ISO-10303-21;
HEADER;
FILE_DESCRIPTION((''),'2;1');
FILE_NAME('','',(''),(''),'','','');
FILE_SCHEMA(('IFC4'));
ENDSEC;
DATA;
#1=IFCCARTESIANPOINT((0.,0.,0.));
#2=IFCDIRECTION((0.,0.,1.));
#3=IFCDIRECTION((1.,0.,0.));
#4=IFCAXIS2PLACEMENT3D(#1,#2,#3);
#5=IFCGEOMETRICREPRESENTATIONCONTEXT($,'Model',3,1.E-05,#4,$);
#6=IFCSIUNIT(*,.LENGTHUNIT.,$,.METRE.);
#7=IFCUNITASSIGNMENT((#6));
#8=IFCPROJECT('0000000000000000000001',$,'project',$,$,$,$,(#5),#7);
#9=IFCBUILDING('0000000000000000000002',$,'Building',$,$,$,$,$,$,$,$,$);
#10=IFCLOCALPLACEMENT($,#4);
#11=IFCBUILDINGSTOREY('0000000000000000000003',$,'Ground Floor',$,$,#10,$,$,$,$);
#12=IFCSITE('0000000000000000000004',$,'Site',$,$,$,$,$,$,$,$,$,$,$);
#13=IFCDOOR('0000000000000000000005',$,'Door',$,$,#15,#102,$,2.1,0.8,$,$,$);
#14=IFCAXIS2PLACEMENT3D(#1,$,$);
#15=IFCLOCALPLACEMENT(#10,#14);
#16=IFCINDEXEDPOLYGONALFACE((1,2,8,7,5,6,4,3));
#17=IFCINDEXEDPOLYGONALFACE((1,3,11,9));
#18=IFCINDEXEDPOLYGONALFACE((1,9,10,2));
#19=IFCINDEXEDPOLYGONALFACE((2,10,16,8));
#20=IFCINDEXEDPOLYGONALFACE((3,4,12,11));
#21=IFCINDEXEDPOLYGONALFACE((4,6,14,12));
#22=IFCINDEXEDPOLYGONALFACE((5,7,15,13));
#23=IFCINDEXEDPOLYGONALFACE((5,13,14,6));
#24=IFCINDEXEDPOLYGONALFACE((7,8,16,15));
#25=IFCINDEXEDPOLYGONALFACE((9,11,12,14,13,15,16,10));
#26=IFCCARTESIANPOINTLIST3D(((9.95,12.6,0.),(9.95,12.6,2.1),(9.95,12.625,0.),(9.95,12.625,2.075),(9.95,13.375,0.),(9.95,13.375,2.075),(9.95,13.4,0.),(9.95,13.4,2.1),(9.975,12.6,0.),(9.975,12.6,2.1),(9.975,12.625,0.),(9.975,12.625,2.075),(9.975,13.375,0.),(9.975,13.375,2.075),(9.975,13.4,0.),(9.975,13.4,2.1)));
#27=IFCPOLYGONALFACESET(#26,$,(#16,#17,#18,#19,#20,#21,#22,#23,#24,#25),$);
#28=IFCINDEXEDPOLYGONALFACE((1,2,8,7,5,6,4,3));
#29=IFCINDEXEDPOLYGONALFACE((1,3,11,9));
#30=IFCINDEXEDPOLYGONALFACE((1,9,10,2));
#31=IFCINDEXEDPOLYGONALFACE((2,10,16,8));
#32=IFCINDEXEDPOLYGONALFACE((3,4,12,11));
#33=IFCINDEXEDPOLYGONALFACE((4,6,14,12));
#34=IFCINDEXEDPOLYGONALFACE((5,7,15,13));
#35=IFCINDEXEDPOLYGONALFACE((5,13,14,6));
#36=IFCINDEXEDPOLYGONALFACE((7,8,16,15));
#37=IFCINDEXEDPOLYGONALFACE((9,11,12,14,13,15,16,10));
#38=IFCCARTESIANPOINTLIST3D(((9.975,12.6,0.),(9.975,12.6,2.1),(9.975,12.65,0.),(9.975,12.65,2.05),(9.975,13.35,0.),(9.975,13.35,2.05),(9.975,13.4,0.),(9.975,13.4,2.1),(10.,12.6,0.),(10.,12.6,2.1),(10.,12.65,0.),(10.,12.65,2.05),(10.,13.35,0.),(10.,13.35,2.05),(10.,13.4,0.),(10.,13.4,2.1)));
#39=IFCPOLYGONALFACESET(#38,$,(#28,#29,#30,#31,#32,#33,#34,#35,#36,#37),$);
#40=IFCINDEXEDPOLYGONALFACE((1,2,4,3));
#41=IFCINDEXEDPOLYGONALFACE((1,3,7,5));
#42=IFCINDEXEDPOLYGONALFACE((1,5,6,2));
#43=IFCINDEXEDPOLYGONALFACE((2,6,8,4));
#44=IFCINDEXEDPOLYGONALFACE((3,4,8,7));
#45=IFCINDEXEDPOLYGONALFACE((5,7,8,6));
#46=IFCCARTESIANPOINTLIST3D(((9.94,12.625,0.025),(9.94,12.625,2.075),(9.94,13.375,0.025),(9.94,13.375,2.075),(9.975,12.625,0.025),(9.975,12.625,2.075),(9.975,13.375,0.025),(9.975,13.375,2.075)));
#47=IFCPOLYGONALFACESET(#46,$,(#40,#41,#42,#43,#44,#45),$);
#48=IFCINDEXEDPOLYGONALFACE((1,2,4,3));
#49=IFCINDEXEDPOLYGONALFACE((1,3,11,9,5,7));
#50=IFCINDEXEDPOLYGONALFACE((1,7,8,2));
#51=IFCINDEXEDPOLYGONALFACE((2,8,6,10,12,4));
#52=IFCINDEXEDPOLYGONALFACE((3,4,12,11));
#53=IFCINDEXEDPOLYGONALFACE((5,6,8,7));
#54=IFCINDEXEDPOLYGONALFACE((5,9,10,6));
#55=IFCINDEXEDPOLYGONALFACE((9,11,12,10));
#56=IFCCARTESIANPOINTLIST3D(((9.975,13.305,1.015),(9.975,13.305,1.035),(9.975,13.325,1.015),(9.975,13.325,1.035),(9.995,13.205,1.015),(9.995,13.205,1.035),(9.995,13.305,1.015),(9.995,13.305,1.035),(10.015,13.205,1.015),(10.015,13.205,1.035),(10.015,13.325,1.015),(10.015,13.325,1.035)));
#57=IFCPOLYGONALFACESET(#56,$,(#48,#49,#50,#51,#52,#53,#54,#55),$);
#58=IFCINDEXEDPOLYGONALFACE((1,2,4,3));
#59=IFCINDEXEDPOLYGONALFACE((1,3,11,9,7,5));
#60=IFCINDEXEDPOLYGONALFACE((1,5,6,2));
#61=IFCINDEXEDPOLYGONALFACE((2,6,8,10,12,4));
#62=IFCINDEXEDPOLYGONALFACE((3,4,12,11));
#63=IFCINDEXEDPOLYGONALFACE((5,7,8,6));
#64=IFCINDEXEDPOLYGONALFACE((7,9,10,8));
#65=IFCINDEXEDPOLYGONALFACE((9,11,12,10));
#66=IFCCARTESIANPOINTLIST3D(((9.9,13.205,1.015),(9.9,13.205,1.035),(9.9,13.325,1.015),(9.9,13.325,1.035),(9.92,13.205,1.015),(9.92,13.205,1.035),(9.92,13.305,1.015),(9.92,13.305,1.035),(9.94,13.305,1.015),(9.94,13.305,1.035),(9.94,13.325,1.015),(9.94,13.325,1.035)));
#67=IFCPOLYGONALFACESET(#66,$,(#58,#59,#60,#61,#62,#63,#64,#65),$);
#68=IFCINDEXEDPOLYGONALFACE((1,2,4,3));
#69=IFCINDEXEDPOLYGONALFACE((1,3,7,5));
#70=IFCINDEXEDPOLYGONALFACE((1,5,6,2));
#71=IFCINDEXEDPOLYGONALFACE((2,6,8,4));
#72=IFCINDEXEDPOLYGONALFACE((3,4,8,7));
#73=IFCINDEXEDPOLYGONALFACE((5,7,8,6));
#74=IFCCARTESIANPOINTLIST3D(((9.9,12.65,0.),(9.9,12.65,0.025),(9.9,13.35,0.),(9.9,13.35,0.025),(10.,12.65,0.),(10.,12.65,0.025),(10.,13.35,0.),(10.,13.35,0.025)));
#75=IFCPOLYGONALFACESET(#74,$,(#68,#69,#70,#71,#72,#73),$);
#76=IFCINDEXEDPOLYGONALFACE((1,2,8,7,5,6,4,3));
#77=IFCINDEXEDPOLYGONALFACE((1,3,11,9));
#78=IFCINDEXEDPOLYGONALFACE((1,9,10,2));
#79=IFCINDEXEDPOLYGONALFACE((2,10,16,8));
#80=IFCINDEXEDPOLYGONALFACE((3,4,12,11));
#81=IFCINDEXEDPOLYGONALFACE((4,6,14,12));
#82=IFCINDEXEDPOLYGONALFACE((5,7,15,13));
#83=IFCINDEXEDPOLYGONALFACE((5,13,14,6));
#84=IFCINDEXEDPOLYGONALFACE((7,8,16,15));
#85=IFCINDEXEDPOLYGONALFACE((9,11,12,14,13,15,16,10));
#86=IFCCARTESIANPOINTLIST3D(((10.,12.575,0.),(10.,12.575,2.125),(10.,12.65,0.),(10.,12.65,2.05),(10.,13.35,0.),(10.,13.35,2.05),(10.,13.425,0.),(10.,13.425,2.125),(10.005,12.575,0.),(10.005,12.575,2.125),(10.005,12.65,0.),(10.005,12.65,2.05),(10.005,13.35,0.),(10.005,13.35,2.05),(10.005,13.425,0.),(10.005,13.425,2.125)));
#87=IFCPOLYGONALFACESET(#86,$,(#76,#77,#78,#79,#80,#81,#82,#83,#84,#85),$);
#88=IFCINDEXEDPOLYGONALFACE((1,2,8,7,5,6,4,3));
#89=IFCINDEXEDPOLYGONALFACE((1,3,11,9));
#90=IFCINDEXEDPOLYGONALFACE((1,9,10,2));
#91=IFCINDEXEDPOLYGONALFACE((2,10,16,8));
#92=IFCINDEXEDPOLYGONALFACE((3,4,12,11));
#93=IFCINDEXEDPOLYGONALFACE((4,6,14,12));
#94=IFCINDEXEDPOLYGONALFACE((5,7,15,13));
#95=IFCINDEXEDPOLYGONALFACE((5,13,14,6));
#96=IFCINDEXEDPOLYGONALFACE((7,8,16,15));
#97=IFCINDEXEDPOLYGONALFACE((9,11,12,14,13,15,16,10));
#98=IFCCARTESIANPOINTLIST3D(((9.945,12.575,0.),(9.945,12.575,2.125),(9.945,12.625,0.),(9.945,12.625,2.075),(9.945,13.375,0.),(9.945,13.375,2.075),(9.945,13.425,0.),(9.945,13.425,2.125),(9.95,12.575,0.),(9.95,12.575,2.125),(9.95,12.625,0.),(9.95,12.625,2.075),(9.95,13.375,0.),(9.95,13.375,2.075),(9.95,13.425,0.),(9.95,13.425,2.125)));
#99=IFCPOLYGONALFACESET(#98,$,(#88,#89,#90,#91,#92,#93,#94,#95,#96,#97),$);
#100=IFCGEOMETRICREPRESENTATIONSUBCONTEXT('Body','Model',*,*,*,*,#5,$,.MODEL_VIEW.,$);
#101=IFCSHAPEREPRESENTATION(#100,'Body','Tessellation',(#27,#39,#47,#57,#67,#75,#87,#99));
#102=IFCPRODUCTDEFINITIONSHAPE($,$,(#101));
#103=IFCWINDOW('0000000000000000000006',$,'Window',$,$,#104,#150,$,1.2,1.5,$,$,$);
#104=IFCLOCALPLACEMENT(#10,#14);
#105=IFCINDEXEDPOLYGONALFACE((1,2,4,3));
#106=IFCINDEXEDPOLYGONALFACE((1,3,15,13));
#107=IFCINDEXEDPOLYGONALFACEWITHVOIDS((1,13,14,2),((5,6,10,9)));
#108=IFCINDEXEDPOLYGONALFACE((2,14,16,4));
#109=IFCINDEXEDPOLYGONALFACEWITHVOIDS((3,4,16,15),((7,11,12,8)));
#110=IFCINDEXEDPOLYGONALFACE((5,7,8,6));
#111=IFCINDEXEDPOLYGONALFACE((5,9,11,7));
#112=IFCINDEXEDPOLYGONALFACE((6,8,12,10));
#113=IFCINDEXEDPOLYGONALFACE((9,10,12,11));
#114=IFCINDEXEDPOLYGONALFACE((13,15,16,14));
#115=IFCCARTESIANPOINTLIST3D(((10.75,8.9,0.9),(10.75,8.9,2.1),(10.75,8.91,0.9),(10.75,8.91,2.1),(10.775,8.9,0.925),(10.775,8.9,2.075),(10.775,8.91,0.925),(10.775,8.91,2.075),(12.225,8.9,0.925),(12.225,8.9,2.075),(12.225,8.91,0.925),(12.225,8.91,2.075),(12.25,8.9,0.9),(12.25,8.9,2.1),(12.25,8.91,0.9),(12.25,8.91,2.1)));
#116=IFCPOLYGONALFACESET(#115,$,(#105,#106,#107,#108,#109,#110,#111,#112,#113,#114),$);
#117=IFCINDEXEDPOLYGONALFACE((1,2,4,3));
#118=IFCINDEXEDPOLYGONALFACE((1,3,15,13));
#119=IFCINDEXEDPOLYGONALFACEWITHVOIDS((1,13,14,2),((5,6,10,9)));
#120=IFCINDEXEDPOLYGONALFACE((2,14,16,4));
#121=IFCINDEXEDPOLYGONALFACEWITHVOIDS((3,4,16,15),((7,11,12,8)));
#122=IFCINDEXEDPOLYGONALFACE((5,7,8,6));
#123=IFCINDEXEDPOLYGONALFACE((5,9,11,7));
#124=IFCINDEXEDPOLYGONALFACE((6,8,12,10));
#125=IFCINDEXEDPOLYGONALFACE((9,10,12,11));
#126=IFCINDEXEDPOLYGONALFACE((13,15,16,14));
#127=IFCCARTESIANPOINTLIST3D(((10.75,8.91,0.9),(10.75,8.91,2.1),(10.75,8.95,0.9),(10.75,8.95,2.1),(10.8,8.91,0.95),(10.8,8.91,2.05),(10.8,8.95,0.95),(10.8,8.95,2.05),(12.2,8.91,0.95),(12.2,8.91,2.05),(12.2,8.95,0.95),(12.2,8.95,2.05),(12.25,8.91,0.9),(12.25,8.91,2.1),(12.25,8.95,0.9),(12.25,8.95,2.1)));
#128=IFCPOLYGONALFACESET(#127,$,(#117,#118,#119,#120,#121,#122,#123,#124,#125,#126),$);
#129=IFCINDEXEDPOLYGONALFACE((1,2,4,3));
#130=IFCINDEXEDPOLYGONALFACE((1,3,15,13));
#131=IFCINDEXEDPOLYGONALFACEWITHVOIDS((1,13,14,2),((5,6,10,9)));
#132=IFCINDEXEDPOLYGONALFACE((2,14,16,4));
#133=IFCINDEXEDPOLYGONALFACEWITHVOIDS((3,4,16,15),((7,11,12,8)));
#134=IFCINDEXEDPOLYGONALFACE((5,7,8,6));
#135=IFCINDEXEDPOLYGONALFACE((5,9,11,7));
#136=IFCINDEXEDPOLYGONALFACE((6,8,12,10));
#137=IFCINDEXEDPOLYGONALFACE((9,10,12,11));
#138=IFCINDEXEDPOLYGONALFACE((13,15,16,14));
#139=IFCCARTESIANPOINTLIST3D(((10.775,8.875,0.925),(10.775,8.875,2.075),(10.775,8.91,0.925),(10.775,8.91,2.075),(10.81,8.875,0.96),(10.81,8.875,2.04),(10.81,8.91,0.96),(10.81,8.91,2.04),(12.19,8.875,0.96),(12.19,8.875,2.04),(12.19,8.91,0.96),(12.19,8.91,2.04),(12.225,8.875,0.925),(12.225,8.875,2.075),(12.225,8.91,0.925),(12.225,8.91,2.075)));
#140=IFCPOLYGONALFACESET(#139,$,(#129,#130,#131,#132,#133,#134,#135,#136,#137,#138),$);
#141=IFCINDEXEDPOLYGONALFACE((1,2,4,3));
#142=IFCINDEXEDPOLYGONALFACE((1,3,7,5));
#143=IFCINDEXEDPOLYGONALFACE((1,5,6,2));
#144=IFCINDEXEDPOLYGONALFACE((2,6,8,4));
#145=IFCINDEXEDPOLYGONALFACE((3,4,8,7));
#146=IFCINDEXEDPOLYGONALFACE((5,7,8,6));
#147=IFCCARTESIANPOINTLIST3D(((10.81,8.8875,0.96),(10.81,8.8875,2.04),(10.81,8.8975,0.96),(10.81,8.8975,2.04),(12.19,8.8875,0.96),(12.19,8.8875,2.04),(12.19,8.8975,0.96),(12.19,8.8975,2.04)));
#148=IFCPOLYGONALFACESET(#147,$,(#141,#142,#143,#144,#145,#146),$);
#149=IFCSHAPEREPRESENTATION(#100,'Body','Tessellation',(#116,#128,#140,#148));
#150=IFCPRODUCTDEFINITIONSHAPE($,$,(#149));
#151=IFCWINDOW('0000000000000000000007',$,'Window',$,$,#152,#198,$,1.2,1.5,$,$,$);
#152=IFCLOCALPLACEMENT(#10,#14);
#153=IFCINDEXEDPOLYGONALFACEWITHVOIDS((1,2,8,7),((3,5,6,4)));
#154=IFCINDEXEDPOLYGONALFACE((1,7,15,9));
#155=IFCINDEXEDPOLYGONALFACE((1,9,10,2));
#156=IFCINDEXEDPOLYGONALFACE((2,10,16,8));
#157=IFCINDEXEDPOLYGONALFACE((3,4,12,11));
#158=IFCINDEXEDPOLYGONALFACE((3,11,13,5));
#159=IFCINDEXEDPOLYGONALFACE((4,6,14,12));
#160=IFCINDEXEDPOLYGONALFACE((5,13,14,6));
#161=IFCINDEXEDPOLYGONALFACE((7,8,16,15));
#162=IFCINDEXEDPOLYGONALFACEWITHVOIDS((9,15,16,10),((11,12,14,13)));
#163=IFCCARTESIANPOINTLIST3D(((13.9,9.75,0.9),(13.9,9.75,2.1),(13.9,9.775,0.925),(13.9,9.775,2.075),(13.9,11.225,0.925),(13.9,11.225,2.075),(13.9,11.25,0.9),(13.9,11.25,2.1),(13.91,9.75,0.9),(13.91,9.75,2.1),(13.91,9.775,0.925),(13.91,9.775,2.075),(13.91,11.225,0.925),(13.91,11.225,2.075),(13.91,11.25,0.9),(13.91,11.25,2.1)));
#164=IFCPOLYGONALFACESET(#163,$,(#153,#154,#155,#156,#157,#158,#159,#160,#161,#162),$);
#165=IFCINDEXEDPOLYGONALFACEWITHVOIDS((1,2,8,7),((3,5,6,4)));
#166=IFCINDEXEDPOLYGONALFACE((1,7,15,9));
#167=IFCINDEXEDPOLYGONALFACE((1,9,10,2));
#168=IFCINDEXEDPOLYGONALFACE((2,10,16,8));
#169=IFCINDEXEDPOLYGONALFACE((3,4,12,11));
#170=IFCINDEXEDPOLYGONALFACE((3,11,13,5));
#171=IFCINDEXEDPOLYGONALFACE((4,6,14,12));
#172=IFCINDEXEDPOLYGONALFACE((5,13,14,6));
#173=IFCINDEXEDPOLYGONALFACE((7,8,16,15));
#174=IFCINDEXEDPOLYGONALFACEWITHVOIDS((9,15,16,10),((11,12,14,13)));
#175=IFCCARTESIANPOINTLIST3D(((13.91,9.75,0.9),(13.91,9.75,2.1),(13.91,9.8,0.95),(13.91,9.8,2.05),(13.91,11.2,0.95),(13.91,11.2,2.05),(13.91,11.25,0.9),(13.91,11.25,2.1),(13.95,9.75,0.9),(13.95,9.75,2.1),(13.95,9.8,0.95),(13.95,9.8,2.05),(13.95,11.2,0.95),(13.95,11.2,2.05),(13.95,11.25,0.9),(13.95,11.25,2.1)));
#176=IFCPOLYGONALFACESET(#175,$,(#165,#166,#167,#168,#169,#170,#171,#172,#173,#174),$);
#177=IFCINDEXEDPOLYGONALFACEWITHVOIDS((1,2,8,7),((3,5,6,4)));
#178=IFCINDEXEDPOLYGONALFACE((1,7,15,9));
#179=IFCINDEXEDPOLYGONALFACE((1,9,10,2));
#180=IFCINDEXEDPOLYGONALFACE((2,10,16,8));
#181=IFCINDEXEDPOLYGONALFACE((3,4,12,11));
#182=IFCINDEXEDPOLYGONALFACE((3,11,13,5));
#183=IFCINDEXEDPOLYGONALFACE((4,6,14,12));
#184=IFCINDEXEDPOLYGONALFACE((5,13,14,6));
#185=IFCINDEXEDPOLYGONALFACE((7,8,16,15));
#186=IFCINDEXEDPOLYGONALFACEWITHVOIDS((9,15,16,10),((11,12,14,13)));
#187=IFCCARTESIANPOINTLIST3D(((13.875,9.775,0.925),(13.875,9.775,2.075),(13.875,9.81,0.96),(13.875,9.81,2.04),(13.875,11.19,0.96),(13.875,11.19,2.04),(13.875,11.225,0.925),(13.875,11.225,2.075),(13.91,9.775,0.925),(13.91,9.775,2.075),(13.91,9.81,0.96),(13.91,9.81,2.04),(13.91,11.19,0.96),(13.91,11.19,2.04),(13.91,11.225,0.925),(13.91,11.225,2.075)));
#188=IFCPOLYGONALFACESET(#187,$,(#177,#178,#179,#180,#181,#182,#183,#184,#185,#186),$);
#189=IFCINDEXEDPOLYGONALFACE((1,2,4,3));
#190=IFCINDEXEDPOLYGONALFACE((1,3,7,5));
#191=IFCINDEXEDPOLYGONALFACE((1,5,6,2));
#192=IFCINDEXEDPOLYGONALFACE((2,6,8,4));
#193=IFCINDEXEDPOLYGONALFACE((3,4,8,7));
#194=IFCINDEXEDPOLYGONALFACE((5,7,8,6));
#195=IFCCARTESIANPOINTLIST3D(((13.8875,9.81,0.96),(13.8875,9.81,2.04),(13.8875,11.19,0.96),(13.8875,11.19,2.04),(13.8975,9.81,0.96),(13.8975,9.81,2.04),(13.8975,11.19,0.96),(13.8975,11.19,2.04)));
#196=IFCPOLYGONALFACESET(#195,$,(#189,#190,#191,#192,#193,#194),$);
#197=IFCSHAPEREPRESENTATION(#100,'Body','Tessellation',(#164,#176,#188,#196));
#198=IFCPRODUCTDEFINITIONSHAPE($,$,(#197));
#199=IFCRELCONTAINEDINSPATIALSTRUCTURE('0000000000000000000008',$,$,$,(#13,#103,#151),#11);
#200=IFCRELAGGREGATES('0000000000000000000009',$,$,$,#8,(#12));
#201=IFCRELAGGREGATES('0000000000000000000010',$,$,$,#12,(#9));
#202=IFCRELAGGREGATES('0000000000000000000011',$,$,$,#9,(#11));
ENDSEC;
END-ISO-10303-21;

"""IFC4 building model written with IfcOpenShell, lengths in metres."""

from ifc_helpers import new_model, si_unit, frame, origin_with_axes, place, context, subcontext, project, spatial, line, indexed_curve, outline, extrude, element, save


model = new_model("IFC4")

# Units and contexts
model_context = context("Model", 3, precision=1e-05, world=origin_with_axes())
body_context = subcontext(model_context, "Body", "Model", "MODEL_VIEW")
ifc_project = project(units=[si_unit("LENGTHUNIT", "METRE")], contexts=[model_context])

# Site, building, storey
site = spatial("IfcSite", under=ifc_project, Name="Site")
building = spatial("IfcBuilding", under=site, Name="Building")
storey_placement = place(None, origin_with_axes())
storey = spatial("IfcBuildingStorey", under=building, at=storey_placement, Name="Ground Floor")

# Door
door_1_placement = place(storey_placement, frame((10.0, 12.6, 0.0), z_axis=(0.0, 0.0, 1.0), x_axis=(0.0, 1.0, 0.0)))
element("IfcDoor", 1, at=door_1_placement, inside=storey, Name="Door", OverallHeight=2.1, OverallWidth=0.8, context=body_context, shape_type="SweptSolid", body=[
    extrude(outline(indexed_curve([(0.0, 0.0), (0.0, 2.1), (0.8, 2.1), (0.8, 0.0), (0.775, 0.0), (0.775, 2.075), (0.025, 2.075), (0.025, 0.0)], segments=[line(1, 2, 3, 4, 5, 6, 7, 8, 1)])), frame((0.0, 0.025, 0.0), z_axis=(0.0, -1.0, 0.0), x_axis=(1.0, 0.0, 0.0)), (0.0, 0.0, -1.0), 0.025),
    extrude(outline(indexed_curve([(0.0, 0.0), (0.0, 2.1), (0.8, 2.1), (0.8, 0.0), (0.75, 0.0), (0.75, 2.05), (0.05, 2.05), (0.05, 0.0)], segments=[line(1, 2, 3, 4, 5, 6, 7, 8, 1)])), frame((0.0, 0.0, 0.0), z_axis=(0.0, -1.0, 0.0), x_axis=(1.0, 0.0, 0.0)), (0.0, 0.0, -1.0), 0.025),
    extrude(outline(indexed_curve([(0.0, 0.0), (0.75, 0.0), (0.75, 0.035), (0.0, 0.035)], segments=[line(1, 2, 3, 4, 1)])), frame((0.025, 0.025, 0.025), z_axis=(0.0, 0.0, 1.0), x_axis=(1.0, 0.0, 0.0)), (0.0, 0.0, 1.0), 2.05),
    extrude(outline(indexed_curve([(0.0, 0.0), (0.0, -0.04), (-0.12, -0.04), (-0.12, -0.02), (-0.02, -0.02), (-0.02, 0.0)], segments=[line(1, 2, 3, 4, 5, 6, 1)])), frame((0.725, 0.025, 1.015), z_axis=(0.0, 0.0, 1.0), x_axis=(1.0, 0.0, 0.0)), (0.0, 0.0, 1.0), 0.02),
    extrude(outline(indexed_curve([(0.0, 0.0), (0.0, 0.04), (-0.12, 0.04), (-0.12, 0.02), (-0.02, 0.02), (-0.02, 0.0)], segments=[line(1, 2, 3, 4, 5, 6, 1)])), frame((0.725, 0.06, 1.015), z_axis=(0.0, 0.0, 1.0), x_axis=(1.0, 0.0, 0.0)), (0.0, 0.0, 1.0), 0.02),
    extrude(outline(indexed_curve([(0.0, 0.0), (0.7, 0.0), (0.7, 0.1), (0.0, 0.1)], segments=[line(1, 2, 3, 4, 1)])), frame((0.05, 0.0, 0.0), z_axis=(0.0, 0.0, 1.0), x_axis=(1.0, 0.0, 0.0)), (0.0, 0.0, 1.0), 0.025),
    extrude(outline(indexed_curve([(0.0, 0.0), (0.0, 2.125), (0.85, 2.125), (0.85, 0.0), (0.775, 0.0), (0.775, 2.05), (0.075, 2.05), (0.075, 0.0)], segments=[line(1, 2, 3, 4, 5, 6, 7, 8, 1)])), frame((-0.025, -0.005, 0.0), z_axis=(0.0, -1.0, 0.0), x_axis=(1.0, 0.0, 0.0)), (0.0, 0.0, -1.0), 0.005),
    extrude(outline(indexed_curve([(0.0, 0.0), (0.0, 2.125), (0.85, 2.125), (0.85, 0.0), (0.8, 0.0), (0.8, 2.075), (0.05, 2.075), (0.05, 0.0)], segments=[line(1, 2, 3, 4, 5, 6, 7, 8, 1)])), frame((-0.025, 0.05, 0.0), z_axis=(0.0, -1.0, 0.0), x_axis=(1.0, 0.0, 0.0)), (0.0, 0.0, -1.0), 0.005),
])

# Windows
for number, where, z_axis, x_axis, name in (
    (2, (12.25, 9.0, 0.9), (0.0, 0.0, 1.0), (-1.0, 0.0, 0.0), "Window"),
    (3, (14.0, 9.75, 0.9), (0.0, 0.0, 1.0), (0.0, 1.0, 0.0), "Window"),
):
    element("IfcWindow", number, at=place(storey_placement, frame(where, z_axis=z_axis, x_axis=x_axis)), inside=storey, Name=name, OverallHeight=1.2, OverallWidth=1.5, context=body_context, shape_type="SweptSolid", body=[
        extrude(outline(indexed_curve([(0.0, 0.0), (1.5, 0.0), (1.5, 1.2), (0.0, 1.2)], segments=[line(1, 2, 3, 4, 1)]), holes=[indexed_curve([(0.025, 0.025), (1.475, 0.025), (1.475, 1.175), (0.025, 1.175)], segments=[line(1, 2, 3, 4, 1)])]), frame((0.0, 0.09, 0.0), z_axis=(0.0, -1.0, 0.0), x_axis=(1.0, 0.0, 0.0)), (0.0, 0.0, -1.0), 0.01),
        extrude(outline(indexed_curve([(0.0, 0.0), (1.5, 0.0), (1.5, 1.2), (0.0, 1.2)], segments=[line(1, 2, 3, 4, 1)]), holes=[indexed_curve([(0.05, 0.05), (1.45, 0.05), (1.45, 1.15), (0.05, 1.15)], segments=[line(1, 2, 3, 4, 1)])]), frame((0.0, 0.05, 0.0), z_axis=(0.0, -1.0, 0.0), x_axis=(1.0, 0.0, 0.0)), (0.0, 0.0, -1.0), 0.04),
        extrude(outline(indexed_curve([(0.0, 0.0), (1.45, 0.0), (1.45, 1.15), (0.0, 1.15)], segments=[line(1, 2, 3, 4, 1)]), holes=[indexed_curve([(0.035, 0.035), (1.415, 0.035), (1.415, 1.115), (0.035, 1.115)], segments=[line(1, 2, 3, 4, 1)])]), frame((0.025, 0.09, 0.025), z_axis=(0.0, -1.0, 0.0), x_axis=(1.0, 0.0, 0.0)), (0.0, 0.0, -1.0), 0.035),
        extrude(outline(indexed_curve([(0.035, 0.035), (1.415, 0.035), (1.415, 1.115), (0.035, 1.115)], segments=[line(1, 2, 3, 4, 1)])), frame((0.025, 0.1025, 0.025), z_axis=(0.0, -1.0, 0.0), x_axis=(1.0, 0.0, 0.0)), (0.0, 0.0, -1.0), 0.01),
    ])

save(model, "model.ifc")
